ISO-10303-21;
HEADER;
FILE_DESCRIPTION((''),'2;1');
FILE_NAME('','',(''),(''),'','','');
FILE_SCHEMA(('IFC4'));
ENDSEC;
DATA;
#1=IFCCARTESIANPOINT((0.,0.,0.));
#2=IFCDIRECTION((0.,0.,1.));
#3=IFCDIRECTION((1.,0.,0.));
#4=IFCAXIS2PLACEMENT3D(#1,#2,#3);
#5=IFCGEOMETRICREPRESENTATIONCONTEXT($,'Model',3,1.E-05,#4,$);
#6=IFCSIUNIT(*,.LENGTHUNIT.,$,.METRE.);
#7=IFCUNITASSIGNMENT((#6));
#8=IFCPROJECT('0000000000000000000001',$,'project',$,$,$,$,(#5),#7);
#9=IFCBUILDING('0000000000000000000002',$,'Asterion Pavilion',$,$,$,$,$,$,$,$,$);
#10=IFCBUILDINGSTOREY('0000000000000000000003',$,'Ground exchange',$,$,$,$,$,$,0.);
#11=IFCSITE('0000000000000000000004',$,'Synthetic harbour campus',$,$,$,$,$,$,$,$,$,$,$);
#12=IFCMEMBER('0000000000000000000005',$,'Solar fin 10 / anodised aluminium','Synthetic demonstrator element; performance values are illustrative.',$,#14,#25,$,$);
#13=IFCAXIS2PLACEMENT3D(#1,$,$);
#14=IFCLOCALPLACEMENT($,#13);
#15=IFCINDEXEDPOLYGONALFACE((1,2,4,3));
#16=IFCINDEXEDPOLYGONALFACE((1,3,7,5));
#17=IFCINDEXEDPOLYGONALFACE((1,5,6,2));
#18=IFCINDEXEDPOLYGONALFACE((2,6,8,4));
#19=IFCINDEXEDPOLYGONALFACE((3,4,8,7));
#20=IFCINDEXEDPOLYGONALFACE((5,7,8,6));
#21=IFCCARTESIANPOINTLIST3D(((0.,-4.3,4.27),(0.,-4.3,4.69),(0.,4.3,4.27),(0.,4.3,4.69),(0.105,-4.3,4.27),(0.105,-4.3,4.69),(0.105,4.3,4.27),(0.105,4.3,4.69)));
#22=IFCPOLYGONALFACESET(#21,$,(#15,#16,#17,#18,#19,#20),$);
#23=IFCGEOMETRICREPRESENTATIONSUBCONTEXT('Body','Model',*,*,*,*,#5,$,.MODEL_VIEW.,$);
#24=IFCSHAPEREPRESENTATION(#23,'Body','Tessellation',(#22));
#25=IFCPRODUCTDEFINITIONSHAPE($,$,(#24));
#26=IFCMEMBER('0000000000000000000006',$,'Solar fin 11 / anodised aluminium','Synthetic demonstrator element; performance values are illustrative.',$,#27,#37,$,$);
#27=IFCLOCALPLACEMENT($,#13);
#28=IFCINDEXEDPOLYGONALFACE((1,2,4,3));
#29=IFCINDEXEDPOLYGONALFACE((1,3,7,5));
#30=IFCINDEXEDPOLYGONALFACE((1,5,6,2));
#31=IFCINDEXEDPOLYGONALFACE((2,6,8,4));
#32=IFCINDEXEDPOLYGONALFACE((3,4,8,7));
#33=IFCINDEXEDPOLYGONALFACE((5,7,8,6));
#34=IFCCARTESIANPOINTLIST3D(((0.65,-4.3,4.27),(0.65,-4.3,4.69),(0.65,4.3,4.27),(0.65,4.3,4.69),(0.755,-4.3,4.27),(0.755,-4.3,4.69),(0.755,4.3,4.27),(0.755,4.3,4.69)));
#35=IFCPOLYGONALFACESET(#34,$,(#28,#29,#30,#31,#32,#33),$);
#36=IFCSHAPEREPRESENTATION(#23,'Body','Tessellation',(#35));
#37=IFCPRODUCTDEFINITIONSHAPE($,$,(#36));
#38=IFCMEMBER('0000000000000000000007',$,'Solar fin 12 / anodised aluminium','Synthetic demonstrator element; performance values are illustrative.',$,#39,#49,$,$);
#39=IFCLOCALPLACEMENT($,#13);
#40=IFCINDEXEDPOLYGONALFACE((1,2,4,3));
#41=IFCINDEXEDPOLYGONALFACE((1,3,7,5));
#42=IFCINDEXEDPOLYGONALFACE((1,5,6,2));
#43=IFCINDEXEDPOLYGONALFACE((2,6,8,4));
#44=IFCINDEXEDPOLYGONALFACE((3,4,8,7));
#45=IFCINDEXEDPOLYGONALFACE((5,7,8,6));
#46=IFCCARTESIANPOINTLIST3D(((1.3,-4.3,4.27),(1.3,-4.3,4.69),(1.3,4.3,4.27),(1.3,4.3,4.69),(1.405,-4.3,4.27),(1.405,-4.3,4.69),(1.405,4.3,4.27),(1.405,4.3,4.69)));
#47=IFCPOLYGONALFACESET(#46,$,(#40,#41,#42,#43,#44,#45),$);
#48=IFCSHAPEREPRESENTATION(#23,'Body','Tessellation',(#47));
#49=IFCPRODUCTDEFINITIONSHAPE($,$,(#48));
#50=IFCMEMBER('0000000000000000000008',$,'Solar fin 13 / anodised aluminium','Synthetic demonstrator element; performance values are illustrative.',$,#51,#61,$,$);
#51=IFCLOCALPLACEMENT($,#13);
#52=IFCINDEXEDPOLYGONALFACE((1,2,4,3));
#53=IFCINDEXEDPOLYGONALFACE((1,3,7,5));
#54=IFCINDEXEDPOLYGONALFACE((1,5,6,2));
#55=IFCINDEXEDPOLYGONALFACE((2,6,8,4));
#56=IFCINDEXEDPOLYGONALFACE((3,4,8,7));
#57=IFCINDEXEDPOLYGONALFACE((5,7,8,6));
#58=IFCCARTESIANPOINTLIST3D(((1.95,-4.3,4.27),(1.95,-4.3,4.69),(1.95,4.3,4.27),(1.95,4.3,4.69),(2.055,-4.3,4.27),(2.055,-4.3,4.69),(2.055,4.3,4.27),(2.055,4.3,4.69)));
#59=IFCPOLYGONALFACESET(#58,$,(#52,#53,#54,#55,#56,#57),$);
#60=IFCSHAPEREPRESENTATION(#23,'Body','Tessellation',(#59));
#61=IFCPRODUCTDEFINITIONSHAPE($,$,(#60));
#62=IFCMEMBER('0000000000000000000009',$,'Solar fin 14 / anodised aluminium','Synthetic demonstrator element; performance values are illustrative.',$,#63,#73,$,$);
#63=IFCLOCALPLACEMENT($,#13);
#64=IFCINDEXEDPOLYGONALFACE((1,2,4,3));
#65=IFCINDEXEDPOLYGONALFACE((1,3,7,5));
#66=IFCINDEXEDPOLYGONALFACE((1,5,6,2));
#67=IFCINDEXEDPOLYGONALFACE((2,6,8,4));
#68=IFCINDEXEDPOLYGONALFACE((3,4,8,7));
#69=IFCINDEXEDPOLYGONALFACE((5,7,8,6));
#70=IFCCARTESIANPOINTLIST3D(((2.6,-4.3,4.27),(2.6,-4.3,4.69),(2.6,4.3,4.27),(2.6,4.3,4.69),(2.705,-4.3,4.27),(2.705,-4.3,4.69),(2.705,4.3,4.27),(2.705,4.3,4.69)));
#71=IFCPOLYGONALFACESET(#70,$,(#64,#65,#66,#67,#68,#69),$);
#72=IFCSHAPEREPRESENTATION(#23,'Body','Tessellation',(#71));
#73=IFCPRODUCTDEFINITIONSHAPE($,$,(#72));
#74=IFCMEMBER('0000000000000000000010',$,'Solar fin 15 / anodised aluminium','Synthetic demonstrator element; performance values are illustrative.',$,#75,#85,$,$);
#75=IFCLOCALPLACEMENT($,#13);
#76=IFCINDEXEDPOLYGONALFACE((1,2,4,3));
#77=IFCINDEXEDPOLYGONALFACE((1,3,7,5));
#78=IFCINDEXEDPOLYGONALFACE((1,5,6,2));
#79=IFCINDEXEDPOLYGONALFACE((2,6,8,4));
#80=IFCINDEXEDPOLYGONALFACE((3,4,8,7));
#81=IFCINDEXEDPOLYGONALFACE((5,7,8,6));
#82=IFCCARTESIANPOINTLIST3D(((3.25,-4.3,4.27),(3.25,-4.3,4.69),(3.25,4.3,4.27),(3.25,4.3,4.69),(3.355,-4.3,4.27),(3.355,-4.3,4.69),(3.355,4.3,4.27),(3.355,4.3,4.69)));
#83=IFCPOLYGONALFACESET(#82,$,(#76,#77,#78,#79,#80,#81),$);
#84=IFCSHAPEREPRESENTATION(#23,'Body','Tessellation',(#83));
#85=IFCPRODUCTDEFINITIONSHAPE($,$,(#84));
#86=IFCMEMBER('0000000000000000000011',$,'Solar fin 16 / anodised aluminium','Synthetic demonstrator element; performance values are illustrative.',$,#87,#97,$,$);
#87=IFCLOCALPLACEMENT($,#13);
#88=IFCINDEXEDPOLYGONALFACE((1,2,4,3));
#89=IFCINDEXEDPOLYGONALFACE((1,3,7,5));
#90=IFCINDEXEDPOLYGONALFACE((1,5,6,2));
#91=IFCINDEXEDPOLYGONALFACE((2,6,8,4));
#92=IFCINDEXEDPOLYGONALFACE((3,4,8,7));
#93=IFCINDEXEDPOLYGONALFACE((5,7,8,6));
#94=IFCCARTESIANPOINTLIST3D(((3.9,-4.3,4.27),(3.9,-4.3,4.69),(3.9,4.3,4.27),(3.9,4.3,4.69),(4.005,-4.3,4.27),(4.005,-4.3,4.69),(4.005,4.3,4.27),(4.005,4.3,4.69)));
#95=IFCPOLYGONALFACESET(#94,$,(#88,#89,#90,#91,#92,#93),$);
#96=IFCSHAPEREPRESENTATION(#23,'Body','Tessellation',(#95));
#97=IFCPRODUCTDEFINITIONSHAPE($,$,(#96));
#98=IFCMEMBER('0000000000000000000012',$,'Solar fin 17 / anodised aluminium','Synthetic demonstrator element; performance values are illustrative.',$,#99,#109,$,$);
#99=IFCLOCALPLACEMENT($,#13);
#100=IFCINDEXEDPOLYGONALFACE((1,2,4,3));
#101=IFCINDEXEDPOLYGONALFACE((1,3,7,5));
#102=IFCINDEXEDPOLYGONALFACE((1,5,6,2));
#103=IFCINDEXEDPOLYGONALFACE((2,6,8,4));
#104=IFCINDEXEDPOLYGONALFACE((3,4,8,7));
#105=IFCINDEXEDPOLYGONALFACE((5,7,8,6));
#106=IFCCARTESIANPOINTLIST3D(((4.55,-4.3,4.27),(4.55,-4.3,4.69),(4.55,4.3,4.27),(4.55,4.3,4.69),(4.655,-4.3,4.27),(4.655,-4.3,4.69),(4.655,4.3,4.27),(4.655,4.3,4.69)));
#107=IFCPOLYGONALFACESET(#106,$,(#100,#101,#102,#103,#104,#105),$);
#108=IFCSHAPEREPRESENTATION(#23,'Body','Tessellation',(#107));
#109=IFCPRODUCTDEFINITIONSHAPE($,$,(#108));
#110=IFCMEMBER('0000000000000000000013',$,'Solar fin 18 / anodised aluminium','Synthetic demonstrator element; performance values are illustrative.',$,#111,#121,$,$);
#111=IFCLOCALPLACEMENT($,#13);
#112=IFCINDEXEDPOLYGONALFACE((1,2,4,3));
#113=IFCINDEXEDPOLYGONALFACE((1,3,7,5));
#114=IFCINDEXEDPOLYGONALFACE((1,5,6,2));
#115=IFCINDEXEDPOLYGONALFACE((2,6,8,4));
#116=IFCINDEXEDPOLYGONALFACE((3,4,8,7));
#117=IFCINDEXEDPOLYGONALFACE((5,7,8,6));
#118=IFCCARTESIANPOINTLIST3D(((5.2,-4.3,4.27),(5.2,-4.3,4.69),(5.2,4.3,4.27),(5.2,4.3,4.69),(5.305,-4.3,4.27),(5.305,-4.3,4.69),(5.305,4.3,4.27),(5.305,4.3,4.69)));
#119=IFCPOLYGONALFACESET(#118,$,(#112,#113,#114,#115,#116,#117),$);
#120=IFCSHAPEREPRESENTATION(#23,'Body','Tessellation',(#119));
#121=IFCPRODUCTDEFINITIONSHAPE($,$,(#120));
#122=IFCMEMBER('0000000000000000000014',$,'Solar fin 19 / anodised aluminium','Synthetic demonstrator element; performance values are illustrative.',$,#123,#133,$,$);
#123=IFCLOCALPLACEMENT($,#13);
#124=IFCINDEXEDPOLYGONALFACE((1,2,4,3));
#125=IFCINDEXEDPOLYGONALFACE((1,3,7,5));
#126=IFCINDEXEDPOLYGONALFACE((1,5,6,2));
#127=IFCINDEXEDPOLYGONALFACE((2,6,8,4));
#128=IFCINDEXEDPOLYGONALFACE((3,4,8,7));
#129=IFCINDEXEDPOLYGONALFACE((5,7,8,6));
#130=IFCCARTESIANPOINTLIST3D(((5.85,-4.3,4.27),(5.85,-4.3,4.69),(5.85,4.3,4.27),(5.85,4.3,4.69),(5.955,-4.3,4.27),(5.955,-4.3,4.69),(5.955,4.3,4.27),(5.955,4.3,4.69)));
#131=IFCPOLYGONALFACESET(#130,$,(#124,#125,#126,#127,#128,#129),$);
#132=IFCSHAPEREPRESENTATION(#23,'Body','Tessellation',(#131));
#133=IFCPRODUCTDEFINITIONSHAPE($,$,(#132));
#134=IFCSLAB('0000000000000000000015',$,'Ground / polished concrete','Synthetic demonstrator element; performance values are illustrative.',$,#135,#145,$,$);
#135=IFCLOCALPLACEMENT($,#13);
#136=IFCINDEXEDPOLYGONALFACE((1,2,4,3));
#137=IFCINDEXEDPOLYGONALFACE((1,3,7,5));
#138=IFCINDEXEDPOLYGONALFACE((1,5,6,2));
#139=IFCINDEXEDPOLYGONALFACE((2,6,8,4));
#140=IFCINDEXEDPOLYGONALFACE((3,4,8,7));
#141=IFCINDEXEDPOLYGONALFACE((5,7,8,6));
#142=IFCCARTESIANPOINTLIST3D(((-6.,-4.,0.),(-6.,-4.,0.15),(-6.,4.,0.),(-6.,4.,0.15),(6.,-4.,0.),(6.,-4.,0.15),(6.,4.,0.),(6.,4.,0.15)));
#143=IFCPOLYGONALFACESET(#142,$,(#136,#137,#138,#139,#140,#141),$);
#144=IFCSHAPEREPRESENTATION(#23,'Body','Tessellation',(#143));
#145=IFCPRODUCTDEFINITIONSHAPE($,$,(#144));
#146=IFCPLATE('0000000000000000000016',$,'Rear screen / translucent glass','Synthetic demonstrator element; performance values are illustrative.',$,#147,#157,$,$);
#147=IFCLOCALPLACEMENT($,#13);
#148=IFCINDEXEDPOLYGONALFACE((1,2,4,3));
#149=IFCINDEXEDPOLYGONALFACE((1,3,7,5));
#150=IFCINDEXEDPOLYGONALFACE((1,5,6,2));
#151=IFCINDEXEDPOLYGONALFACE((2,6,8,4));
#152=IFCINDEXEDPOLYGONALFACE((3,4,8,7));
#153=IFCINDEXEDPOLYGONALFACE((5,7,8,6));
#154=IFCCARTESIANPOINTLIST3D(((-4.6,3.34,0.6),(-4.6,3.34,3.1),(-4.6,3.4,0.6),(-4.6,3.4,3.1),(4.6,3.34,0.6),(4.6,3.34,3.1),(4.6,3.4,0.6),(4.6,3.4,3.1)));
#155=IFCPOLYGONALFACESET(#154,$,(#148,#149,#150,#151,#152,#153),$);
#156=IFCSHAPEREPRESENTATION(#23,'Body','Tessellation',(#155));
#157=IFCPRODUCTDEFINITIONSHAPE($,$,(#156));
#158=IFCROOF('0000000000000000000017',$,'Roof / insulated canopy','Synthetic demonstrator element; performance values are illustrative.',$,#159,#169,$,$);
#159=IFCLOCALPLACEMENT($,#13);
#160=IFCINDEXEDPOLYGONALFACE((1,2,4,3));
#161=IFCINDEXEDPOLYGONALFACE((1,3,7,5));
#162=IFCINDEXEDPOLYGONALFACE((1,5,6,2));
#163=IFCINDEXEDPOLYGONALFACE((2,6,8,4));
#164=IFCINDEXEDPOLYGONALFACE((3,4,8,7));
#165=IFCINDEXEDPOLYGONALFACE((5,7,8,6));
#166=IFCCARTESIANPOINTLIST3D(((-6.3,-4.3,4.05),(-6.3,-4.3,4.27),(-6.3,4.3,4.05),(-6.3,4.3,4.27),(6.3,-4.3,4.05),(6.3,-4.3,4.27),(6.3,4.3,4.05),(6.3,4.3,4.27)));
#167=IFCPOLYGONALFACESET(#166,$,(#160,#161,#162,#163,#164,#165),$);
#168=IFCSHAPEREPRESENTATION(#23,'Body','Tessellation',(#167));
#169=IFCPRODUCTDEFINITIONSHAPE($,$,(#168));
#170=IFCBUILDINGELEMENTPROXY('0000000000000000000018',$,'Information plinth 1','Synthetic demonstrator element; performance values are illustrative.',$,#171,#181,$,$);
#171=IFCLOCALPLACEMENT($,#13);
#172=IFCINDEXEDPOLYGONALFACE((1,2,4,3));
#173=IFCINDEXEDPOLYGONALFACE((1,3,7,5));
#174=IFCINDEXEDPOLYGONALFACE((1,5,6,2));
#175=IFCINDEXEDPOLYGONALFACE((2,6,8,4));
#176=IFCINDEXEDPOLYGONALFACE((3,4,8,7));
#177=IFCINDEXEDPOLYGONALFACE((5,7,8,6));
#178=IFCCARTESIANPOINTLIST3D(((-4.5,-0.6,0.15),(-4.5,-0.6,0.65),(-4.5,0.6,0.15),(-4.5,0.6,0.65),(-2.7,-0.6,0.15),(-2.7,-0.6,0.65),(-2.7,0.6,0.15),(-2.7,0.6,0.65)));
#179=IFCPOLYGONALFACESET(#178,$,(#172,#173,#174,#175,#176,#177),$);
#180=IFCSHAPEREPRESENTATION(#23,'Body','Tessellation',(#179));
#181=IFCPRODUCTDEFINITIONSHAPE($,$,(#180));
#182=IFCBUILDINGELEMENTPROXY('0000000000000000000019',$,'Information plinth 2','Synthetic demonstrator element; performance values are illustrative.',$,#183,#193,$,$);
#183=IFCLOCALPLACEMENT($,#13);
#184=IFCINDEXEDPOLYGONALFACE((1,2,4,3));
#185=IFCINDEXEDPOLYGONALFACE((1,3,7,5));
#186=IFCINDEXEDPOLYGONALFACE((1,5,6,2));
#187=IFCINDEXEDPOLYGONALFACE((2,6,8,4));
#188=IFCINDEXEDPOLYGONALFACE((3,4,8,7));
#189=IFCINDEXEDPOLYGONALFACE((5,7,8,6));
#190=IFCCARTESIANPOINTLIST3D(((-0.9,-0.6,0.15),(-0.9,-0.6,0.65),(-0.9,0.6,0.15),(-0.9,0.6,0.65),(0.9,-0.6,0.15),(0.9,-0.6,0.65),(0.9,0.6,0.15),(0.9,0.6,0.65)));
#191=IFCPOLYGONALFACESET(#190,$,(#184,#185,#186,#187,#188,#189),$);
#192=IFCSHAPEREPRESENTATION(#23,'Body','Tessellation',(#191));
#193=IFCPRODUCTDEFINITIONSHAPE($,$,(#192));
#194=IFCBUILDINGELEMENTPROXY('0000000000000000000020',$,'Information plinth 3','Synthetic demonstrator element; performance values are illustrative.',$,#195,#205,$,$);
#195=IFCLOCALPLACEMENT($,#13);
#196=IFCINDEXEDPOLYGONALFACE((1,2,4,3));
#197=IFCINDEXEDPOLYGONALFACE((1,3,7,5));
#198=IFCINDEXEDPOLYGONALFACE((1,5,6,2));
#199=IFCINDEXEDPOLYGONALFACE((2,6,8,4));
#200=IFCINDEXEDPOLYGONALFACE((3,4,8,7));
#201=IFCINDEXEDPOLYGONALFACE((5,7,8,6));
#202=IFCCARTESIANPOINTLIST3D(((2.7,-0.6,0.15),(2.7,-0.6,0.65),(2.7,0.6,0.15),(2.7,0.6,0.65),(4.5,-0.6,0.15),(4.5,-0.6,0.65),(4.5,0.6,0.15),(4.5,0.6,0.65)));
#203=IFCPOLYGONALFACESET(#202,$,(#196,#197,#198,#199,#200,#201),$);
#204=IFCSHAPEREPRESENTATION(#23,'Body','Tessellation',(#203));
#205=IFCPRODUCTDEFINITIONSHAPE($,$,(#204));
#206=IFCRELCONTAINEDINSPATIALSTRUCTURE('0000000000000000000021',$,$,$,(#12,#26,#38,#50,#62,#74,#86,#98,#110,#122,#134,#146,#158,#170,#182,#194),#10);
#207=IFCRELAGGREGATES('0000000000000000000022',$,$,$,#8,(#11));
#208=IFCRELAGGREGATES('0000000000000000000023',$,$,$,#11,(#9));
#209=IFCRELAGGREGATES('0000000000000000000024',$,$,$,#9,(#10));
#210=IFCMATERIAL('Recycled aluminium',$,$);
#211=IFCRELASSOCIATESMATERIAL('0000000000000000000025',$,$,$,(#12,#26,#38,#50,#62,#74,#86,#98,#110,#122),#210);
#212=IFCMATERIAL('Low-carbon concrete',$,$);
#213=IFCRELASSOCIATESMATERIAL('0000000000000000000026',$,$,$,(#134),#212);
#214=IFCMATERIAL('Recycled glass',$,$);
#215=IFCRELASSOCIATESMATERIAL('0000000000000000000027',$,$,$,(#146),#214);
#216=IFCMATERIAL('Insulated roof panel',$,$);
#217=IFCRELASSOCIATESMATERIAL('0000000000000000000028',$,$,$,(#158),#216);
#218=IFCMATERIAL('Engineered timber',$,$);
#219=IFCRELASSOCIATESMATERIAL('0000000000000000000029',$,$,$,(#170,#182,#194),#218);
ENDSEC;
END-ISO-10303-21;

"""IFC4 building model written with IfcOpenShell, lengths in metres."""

from ifc_helpers import new_model, si_unit, frame, origin_with_axes, place, context, subcontext, project, spatial, indexed_curve, outline, extrude, material, element, save


model = new_model("IFC4")

# Units and contexts
model_context = context("Model", 3, precision=1e-05, world=origin_with_axes())
body_context = subcontext(model_context, "Body", "Model", "MODEL_VIEW")
ifc_project = project(units=[si_unit("LENGTHUNIT", "METRE")], contexts=[model_context])

# Site, building, storey
site = spatial("IfcSite", under=ifc_project, Name="Synthetic harbour campus")
building = spatial("IfcBuilding", under=site, Name="Asterion Pavilion")
storey = spatial("IfcBuildingStorey", under=building, Name="Ground exchange", Elevation=0.0)

# Shared definitions
ifc_material_1 = material(Name="Low-carbon concrete")

# Shared definitions
ifc_material_2 = material(Name="Recycled aluminium")

# Shared definitions
ifc_material_3 = material(Name="Engineered timber")

# Members
for number, where, z_axis, x_axis, name in (
    (1, (0.0, -4.3, 4.27), (0.0, 0.0, 1.0), (1.0, 0.0, 0.0), "Solar fin 10 / anodised aluminium"),
    (2, (0.65, -4.3, 4.27), (0.0, 0.0, 1.0), (1.0, 0.0, 0.0), "Solar fin 11 / anodised aluminium"),
    (3, (1.3, -4.3, 4.27), (0.0, 0.0, 1.0), (1.0, 0.0, 0.0), "Solar fin 12 / anodised aluminium"),
    (4, (1.95, -4.3, 4.27), (0.0, 0.0, 1.0), (1.0, 0.0, 0.0), "Solar fin 13 / anodised aluminium"),
    (5, (2.6, -4.3, 4.27), (0.0, 0.0, 1.0), (1.0, 0.0, 0.0), "Solar fin 14 / anodised aluminium"),
    (6, (3.25, -4.3, 4.27), (0.0, 0.0, 1.0), (1.0, 0.0, 0.0), "Solar fin 15 / anodised aluminium"),
    (7, (3.9, -4.3, 4.27), (0.0, 0.0, 1.0), (1.0, 0.0, 0.0), "Solar fin 16 / anodised aluminium"),
    (8, (4.55, -4.3, 4.27), (0.0, 0.0, 1.0), (1.0, 0.0, 0.0), "Solar fin 17 / anodised aluminium"),
    (9, (5.2, -4.3, 4.27), (0.0, 0.0, 1.0), (1.0, 0.0, 0.0), "Solar fin 18 / anodised aluminium"),
    (10, (5.85, -4.3, 4.27), (0.0, 0.0, 1.0), (1.0, 0.0, 0.0), "Solar fin 19 / anodised aluminium"),
):
    element("IfcMember", number, at=place(None, frame(where, z_axis=z_axis, x_axis=x_axis)), inside=storey, material=ifc_material_2, Name=name, Description="Synthetic demonstrator element; performance values are illustrative.", context=body_context, shape_type="SweptSolid", body=[
        extrude(outline(indexed_curve([(0.0, 0.0), (0.0, 8.6), (0.105, 8.6), (0.105, 0.0), (0.0, 0.0)], self_intersect=False)), origin_with_axes(), (0.0, 0.0, 1.0), 0.42),
    ])

# Slab
slab_placement = place(None, frame((-6.0, -4.0, 0.0), z_axis=(0.0, 0.0, 1.0), x_axis=(1.0, 0.0, 0.0)))
element("IfcSlab", 11, at=slab_placement, inside=storey, material=ifc_material_1, Name="Ground / polished concrete", Description="Synthetic demonstrator element; performance values are illustrative.", context=body_context, shape_type="SweptSolid", body=[
    extrude(outline(indexed_curve([(0.0, 0.0), (0.0, 8.0), (12.0, 8.0), (12.0, 0.0), (0.0, 0.0)], self_intersect=False)), origin_with_axes(), (0.0, 0.0, 1.0), 0.15),
])

# Plate
ifc_material_4 = material(Name="Recycled glass")
plate_placement = place(None, frame((-4.6, 3.34, 0.6), z_axis=(0.0, 0.0, 1.0), x_axis=(1.0, 0.0, 0.0)))
element("IfcPlate", 12, at=plate_placement, inside=storey, material=ifc_material_4, Name="Rear screen / translucent glass", Description="Synthetic demonstrator element; performance values are illustrative.", context=body_context, shape_type="SweptSolid", body=[
    extrude(outline(indexed_curve([(0.0, 0.0), (0.0, 0.06), (9.2, 0.06), (9.2, 0.0), (0.0, 0.0)], self_intersect=False)), origin_with_axes(), (0.0, 0.0, 1.0), 2.5),
])

# Roof
ifc_material_5 = material(Name="Insulated roof panel")
roof_placement = place(None, frame((-6.3, -4.3, 4.05), z_axis=(0.0, 0.0, 1.0), x_axis=(1.0, 0.0, 0.0)))
element("IfcRoof", 13, at=roof_placement, inside=storey, material=ifc_material_5, Name="Roof / insulated canopy", Description="Synthetic demonstrator element; performance values are illustrative.", context=body_context, shape_type="SweptSolid", body=[
    extrude(outline(indexed_curve([(0.0, 0.0), (0.0, 8.6), (12.6, 8.6), (12.6, 0.0), (0.0, 0.0)], self_intersect=False)), origin_with_axes(), (0.0, 0.0, 1.0), 0.22),
])

# Building element proxies
for number, where, z_axis, x_axis, name in (
    (14, (-4.5, -0.6, 0.15), (0.0, 0.0, 1.0), (1.0, 0.0, 0.0), "Information plinth 1"),
    (15, (-0.9, -0.6, 0.15), (0.0, 0.0, 1.0), (1.0, 0.0, 0.0), "Information plinth 2"),
    (16, (2.7, -0.6, 0.15), (0.0, 0.0, 1.0), (1.0, 0.0, 0.0), "Information plinth 3"),
):
    element("IfcBuildingElementProxy", number, at=place(None, frame(where, z_axis=z_axis, x_axis=x_axis)), inside=storey, material=ifc_material_3, Name=name, Description="Synthetic demonstrator element; performance values are illustrative.", context=body_context, shape_type="SweptSolid", body=[
        extrude(outline(indexed_curve([(0.0, 0.0), (0.0, 1.2), (1.8, 1.2), (1.8, 0.0), (0.0, 0.0)], self_intersect=False)), origin_with_axes(), (0.0, 0.0, 1.0), 0.5),
    ])

save(model, "model.ifc")
